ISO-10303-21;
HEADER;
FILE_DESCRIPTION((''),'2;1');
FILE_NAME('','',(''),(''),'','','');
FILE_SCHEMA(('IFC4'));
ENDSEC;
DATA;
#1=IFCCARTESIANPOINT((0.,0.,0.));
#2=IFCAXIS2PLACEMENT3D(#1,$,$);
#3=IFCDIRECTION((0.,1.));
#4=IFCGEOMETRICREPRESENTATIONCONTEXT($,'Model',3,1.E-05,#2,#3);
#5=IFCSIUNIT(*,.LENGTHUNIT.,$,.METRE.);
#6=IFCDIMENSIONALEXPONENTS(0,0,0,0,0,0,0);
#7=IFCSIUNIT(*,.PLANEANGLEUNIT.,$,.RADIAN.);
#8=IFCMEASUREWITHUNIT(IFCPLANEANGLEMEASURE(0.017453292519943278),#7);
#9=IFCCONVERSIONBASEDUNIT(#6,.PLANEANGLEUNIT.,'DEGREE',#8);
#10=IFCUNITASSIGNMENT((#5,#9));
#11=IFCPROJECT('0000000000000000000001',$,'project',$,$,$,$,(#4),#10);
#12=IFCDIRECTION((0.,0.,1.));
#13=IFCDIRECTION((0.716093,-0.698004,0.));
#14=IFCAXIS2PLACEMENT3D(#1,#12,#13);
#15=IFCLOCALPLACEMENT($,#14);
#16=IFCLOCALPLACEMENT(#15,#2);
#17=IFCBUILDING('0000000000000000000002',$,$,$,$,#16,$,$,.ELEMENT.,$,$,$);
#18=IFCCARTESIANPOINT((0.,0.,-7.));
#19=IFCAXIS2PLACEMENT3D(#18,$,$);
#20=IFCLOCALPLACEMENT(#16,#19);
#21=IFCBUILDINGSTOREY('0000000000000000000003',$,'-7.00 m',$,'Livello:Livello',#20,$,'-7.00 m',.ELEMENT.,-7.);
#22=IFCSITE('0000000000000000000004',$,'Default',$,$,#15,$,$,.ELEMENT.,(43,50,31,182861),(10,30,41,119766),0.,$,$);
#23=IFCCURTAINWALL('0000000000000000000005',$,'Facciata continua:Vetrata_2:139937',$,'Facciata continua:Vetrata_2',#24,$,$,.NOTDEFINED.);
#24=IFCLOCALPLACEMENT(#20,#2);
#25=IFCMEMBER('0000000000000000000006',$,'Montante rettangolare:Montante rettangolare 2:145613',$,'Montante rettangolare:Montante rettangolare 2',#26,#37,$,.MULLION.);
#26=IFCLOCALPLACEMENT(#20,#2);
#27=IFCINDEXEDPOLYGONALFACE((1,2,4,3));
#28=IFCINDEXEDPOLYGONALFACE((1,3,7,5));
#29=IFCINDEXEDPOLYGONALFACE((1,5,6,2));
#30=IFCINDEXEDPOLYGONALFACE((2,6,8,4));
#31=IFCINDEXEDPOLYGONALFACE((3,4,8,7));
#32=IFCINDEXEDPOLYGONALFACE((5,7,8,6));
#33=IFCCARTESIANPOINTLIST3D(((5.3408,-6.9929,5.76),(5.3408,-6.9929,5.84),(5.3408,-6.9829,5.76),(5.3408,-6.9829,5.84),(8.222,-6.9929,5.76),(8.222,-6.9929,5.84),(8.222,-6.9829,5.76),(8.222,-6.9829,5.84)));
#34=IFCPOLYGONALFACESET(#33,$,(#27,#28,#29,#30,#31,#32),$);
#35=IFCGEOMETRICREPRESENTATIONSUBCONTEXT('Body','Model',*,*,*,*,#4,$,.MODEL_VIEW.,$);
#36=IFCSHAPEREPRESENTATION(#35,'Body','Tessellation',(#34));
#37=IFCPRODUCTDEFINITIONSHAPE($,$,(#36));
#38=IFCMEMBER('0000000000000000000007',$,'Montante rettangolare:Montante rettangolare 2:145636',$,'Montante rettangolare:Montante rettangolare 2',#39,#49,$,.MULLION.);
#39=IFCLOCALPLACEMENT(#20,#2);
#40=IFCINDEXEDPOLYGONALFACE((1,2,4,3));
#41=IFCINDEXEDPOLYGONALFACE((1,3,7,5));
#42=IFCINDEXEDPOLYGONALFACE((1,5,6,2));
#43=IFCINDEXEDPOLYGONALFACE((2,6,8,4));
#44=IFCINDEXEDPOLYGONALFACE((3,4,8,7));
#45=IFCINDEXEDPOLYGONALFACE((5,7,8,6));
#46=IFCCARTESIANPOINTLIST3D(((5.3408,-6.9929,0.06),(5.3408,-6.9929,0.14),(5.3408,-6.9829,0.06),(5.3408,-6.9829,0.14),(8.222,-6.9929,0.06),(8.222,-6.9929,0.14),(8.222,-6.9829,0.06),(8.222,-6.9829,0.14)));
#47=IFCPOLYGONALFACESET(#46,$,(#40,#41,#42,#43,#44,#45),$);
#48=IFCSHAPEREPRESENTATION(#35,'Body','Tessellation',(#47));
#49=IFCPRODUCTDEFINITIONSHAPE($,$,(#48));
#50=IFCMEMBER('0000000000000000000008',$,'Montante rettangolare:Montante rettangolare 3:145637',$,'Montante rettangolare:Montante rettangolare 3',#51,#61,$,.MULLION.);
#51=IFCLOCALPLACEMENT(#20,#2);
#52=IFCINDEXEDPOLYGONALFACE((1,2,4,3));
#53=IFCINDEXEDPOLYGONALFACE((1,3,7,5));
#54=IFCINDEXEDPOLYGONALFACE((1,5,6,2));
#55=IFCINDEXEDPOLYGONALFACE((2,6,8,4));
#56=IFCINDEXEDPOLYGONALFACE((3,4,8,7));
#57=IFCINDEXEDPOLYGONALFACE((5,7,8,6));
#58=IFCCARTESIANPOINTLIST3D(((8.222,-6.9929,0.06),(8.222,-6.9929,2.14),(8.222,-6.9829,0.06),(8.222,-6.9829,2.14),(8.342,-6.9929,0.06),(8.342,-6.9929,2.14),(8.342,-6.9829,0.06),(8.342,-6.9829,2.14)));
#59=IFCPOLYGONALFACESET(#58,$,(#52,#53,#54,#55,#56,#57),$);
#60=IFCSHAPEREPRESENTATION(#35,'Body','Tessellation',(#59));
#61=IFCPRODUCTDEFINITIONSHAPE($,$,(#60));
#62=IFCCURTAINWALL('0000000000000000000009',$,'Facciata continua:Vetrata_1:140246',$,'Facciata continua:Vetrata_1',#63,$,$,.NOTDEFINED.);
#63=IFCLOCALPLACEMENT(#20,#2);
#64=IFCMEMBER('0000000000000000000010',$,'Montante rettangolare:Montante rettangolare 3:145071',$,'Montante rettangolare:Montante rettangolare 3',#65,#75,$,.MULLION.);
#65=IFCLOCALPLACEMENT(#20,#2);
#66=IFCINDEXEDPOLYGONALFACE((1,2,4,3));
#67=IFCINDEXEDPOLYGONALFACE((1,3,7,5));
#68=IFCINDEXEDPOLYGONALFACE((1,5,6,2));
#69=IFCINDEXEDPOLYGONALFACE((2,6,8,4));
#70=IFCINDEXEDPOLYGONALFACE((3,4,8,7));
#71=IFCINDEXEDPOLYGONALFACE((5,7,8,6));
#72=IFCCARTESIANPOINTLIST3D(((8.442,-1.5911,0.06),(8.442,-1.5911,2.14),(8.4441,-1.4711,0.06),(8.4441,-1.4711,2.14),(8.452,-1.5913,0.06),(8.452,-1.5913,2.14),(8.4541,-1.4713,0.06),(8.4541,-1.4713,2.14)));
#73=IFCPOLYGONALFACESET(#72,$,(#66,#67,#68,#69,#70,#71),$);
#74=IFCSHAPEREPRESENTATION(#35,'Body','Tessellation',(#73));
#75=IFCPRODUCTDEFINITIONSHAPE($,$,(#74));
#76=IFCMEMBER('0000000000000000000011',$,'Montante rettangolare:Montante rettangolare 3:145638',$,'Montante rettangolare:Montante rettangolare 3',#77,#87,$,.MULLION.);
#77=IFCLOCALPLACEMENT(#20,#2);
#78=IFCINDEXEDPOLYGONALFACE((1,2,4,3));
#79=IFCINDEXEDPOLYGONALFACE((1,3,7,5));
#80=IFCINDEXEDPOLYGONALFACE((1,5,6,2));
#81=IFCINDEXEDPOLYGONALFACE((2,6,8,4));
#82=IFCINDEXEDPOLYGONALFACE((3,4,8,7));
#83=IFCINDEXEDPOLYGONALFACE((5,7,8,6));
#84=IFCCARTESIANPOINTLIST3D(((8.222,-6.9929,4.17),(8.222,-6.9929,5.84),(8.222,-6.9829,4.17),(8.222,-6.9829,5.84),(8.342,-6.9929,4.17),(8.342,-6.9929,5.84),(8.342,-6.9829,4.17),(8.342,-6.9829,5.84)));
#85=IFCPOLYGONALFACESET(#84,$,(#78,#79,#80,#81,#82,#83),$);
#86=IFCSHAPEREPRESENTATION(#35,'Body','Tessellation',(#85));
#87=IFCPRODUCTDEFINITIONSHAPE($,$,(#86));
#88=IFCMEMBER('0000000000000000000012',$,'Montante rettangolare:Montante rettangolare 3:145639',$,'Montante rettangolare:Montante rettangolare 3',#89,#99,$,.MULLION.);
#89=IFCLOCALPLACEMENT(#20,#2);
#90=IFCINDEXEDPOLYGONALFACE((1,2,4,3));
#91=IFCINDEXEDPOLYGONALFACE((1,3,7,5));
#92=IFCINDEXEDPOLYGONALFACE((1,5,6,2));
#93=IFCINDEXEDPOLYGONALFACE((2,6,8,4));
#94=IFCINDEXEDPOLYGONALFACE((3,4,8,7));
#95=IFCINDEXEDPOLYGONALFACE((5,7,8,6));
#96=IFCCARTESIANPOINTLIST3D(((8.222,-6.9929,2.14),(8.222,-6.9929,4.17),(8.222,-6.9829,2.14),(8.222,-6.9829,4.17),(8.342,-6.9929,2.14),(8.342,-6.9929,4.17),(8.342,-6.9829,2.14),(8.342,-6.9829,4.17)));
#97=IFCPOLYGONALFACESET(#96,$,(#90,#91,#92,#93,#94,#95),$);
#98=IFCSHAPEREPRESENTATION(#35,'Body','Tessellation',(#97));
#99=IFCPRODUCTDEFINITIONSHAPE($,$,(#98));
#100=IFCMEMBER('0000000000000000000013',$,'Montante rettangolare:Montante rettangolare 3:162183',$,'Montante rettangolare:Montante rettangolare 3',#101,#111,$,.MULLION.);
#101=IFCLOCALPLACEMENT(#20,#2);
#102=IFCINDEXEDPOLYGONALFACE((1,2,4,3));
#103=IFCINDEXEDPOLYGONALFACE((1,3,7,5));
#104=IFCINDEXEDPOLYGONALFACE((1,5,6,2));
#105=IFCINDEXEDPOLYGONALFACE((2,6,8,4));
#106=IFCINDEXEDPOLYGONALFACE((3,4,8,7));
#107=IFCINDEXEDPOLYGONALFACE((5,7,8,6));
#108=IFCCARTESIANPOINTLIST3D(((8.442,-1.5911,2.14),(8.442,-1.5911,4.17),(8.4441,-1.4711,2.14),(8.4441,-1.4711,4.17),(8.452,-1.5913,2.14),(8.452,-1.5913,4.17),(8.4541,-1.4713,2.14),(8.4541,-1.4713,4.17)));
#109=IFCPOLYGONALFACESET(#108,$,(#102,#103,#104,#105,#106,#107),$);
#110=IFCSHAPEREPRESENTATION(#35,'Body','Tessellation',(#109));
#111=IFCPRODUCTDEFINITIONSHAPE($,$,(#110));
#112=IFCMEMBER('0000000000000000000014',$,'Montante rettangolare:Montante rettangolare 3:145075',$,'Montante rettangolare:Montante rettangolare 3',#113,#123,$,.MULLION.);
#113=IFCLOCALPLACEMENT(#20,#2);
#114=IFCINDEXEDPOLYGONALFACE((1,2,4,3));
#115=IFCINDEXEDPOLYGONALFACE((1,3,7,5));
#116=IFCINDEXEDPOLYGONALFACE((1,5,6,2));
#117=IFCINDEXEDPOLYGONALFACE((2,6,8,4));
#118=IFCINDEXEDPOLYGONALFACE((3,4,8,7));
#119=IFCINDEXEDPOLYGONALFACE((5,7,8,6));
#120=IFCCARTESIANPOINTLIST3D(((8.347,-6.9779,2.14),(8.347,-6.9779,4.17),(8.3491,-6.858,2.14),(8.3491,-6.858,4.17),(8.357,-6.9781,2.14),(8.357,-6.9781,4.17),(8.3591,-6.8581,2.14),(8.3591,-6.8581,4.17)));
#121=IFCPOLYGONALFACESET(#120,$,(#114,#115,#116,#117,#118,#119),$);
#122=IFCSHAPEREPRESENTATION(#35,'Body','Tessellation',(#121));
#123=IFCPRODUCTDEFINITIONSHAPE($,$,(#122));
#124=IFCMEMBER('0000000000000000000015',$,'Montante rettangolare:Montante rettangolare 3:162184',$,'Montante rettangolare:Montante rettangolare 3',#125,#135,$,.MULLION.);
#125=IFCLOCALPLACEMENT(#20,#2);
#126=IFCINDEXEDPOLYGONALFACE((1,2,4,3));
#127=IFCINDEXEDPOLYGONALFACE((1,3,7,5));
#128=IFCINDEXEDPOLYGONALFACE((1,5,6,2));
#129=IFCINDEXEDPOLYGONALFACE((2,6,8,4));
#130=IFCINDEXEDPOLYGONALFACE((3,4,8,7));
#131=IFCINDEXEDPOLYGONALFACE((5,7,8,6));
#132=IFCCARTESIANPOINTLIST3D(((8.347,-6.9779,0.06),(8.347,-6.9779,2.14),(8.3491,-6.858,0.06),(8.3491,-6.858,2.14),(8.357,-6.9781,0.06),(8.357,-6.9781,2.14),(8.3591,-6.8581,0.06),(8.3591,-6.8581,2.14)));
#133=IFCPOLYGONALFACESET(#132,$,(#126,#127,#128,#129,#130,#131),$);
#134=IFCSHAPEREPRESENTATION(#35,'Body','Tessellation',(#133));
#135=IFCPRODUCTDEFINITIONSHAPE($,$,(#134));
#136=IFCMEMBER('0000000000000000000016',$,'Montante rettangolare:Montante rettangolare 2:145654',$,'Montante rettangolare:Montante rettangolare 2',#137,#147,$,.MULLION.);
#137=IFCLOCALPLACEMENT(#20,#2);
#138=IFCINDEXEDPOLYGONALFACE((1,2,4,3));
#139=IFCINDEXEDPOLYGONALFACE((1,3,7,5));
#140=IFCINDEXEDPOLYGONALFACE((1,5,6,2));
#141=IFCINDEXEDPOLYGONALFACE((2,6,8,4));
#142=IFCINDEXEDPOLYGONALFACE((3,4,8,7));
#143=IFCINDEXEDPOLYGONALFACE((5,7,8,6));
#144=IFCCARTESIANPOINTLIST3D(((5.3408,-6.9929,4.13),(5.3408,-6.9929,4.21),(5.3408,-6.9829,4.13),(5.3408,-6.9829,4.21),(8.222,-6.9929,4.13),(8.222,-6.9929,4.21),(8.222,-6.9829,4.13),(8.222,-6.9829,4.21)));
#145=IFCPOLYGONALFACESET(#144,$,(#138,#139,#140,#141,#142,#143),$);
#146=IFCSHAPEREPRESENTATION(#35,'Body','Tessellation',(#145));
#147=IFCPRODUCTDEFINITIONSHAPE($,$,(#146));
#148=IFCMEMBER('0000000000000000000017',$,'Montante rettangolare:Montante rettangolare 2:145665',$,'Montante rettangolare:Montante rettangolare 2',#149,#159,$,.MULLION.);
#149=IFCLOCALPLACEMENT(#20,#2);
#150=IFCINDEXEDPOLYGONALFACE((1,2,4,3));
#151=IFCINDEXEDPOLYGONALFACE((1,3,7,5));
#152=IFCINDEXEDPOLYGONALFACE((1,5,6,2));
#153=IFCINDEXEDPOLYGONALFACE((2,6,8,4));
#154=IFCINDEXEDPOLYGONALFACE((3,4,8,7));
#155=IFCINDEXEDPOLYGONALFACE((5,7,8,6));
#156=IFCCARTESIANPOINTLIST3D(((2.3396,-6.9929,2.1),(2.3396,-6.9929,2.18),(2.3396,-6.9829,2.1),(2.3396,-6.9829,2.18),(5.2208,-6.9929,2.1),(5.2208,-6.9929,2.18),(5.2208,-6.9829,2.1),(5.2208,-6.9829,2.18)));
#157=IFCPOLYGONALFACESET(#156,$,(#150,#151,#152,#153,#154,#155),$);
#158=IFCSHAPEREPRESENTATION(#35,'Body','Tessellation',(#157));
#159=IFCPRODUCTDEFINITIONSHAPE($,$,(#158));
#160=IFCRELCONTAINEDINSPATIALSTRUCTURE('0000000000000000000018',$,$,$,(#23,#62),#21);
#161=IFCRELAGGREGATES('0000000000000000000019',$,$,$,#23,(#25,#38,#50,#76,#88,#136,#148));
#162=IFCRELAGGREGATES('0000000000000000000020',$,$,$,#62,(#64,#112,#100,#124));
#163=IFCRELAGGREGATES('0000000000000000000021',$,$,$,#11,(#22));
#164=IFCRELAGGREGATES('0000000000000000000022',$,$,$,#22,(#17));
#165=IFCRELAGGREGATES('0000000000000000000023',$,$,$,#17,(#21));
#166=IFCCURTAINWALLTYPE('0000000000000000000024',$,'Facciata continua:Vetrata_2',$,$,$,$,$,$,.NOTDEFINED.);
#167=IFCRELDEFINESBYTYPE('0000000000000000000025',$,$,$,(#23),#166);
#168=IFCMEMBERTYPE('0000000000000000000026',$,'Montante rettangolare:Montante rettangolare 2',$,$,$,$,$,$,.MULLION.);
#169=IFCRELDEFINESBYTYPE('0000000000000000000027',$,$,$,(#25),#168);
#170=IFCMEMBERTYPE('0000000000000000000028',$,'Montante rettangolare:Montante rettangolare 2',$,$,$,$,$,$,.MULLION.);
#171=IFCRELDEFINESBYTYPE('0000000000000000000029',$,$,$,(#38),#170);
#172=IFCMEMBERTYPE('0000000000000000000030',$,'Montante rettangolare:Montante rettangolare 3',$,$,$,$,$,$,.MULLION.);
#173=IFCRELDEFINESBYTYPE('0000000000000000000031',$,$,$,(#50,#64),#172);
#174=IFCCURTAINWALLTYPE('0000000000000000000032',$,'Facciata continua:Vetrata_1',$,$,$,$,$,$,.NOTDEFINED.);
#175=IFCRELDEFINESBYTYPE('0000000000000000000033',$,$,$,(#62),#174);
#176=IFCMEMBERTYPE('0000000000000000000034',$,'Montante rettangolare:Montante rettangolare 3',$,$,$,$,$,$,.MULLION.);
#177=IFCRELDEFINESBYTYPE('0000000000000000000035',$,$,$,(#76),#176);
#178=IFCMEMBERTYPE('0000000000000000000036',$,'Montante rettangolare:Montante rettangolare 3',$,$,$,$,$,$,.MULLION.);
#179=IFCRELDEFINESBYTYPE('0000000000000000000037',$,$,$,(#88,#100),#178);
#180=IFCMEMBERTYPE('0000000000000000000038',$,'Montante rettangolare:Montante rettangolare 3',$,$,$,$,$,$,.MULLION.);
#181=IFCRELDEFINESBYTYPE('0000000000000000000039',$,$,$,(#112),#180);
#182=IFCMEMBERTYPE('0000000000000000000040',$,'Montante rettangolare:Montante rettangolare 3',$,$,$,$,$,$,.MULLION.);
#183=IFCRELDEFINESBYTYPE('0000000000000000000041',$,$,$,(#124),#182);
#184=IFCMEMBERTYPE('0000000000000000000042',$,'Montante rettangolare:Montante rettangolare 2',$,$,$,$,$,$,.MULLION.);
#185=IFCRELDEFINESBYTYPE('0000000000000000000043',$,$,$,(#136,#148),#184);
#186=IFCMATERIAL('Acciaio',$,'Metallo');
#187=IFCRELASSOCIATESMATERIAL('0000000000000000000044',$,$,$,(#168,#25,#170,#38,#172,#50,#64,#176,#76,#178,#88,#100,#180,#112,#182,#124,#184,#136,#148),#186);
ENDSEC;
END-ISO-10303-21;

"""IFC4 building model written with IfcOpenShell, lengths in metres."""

from ifc_helpers import new_model, entity, si_unit, converted_unit, direction, frame, origin, place, context, subcontext, project, spatial, indexed_curve, outline, extrude, source, transform, mapped, material, type_object, type_shapes, element, aggregate, save


model = new_model("IFC4")

# Units and contexts
model_context = context("Model", 3, precision=1e-05, world=origin(), true_north=direction((0.0, 1.0)))
body_context = subcontext(model_context, "Body", "Model", "MODEL_VIEW")
ifc_project = project(units=[si_unit("LENGTHUNIT", "METRE"), converted_unit("PLANEANGLEUNIT", "DEGREE", entity("IfcPlaneAngleMeasure", 0.017453292519943278), si_unit("PLANEANGLEUNIT", "RADIAN"), dimensions=[0, 0, 0, 0, 0, 0, 0])], contexts=[model_context])

# Site, building, storey
site_placement = place(None, frame((0.0, 0.0, 0.0), z_axis=(0.0, 0.0, 1.0), x_axis=(0.716093, -0.698004, 0.0)))
site = spatial("IfcSite", under=ifc_project, at=site_placement, Name="Default", CompositionType="ELEMENT", RefLatitude=(43, 50, 31, 182861), RefLongitude=(10, 30, 41, 119766), RefElevation=0.0)
building_placement = place(site_placement, origin())
building = spatial("IfcBuilding", under=site, at=building_placement, CompositionType="ELEMENT")
storey_placement = place(building_placement, frame((0.0, 0.0, -7.0)))
storey = spatial("IfcBuildingStorey", under=building, at=storey_placement, Name="-7.00 m", ObjectType="Livello:Livello", LongName="-7.00 m", CompositionType="ELEMENT", Elevation=-7.0)

# Curtain wall, members
curtain_wall_type_1 = type_object("IfcCurtainWallType", Name="Facciata continua:Vetrata_2", PredefinedType="NOTDEFINED")
curtain_wall_1_placement = place(storey_placement, frame((0.0, 0.0, 7.0)))
curtain_wall_1 = element("IfcCurtainWall", 1, at=curtain_wall_1_placement, inside=storey, type_object=curtain_wall_type_1, Name="Facciata continua:Vetrata_2:139937", ObjectType="Facciata continua:Vetrata_2", PredefinedType="NOTDEFINED")
ifc_material_1 = material(Name="Acciaio", Category="Metallo")
member_type_1 = type_object("IfcMemberType", Name="Montante rettangolare:Montante rettangolare 2", PredefinedType="MULLION", material=ifc_material_1)
shared_shape_1 = source(origin(), body_context, "Body", "SweptSolid", [
    extrude(outline(indexed_curve([(-0.04, -0.005), (0.04, -0.005), (0.04, 0.005), (-0.04, 0.005), (-0.04, -0.005)], self_intersect=False)), frame((-0.04, 0.01, -2.8812), z_axis=(0.0, 0.0, 1.0), x_axis=(-1.0, 0.0, 0.0)), (0.0, 0.0, 1.0), 2.8812),
])
type_shapes(member_type_1, [shared_shape_1])
member_1_placement = place(curtain_wall_1_placement, frame((8.222, -6.9779, -1.16), z_axis=(1.0, 0.0, 0.0), x_axis=(0.0, 0.0, 1.0)))
member_1 = element("IfcMember", 2, at=member_1_placement, type_object=member_type_1, material=ifc_material_1, Name="Montante rettangolare:Montante rettangolare 2:145613", ObjectType="Montante rettangolare:Montante rettangolare 2", PredefinedType="MULLION", context=body_context, shape_type="MappedRepresentation", body=[
    mapped(shared_shape_1, transform((0.0, 0.0, 0.0), scale=1.0)),
])
member_type_2 = type_object("IfcMemberType", Name="Montante rettangolare:Montante rettangolare 2", PredefinedType="MULLION", material=ifc_material_1)
shared_shape_2 = source(origin(), body_context, "Body", "SweptSolid", [
    extrude(outline(indexed_curve([(-0.04, -0.005), (0.04, -0.005), (0.04, 0.005), (-0.04, 0.005), (-0.04, -0.005)], self_intersect=False)), frame((-0.04, 0.01, -2.8812), z_axis=(0.0, 0.0, 1.0), x_axis=(-1.0, 0.0, 0.0)), (0.0, 0.0, 1.0), 2.8812),
])
type_shapes(member_type_2, [shared_shape_2])
member_2_placement = place(curtain_wall_1_placement, frame((5.3408, -6.9779, -6.94), z_axis=(-1.0, 0.0, 0.0), x_axis=(0.0, 0.0, -1.0)))
member_2 = element("IfcMember", 3, at=member_2_placement, type_object=member_type_2, material=ifc_material_1, Name="Montante rettangolare:Montante rettangolare 2:145636", ObjectType="Montante rettangolare:Montante rettangolare 2", PredefinedType="MULLION", context=body_context, shape_type="MappedRepresentation", body=[
    mapped(shared_shape_2, transform((0.0, 0.0, 0.0), scale=1.0)),
])
member_type_3 = type_object("IfcMemberType", Name="Montante rettangolare:Montante rettangolare 3", PredefinedType="MULLION", material=ifc_material_1)
shared_shape_3 = source(origin(), body_context, "Body", "SweptSolid", [
    extrude(outline(indexed_curve([(-0.06, -0.005), (0.06, -0.005), (0.06, 0.005), (-0.06, 0.005), (-0.06, -0.005)], self_intersect=False)), frame((-0.06, 0.01, -2.08), z_axis=(0.0, 0.0, 1.0), x_axis=(-1.0, 0.0, 0.0)), (0.0, 0.0, 1.0), 2.08),
])
type_shapes(member_type_3, [shared_shape_3])
member_3_placement = place(curtain_wall_1_placement, frame((8.342, -6.9779, -6.94), z_axis=(0.0, 0.0, -1.0), x_axis=(1.0, 0.0, 0.0)))
member_3 = element("IfcMember", 4, at=member_3_placement, type_object=member_type_3, material=ifc_material_1, Name="Montante rettangolare:Montante rettangolare 3:145637", ObjectType="Montante rettangolare:Montante rettangolare 3", PredefinedType="MULLION", context=body_context, shape_type="MappedRepresentation", body=[
    mapped(shared_shape_3, transform((0.0, 0.0, 0.0), scale=1.0)),
])

# Curtain wall, member
curtain_wall_type_2 = type_object("IfcCurtainWallType", Name="Facciata continua:Vetrata_1", PredefinedType="NOTDEFINED")
curtain_wall_2_placement = place(storey_placement, frame((0.0, 0.0, 7.0)))
curtain_wall_2 = element("IfcCurtainWall", 5, at=curtain_wall_2_placement, inside=storey, type_object=curtain_wall_type_2, Name="Facciata continua:Vetrata_1:140246", ObjectType="Facciata continua:Vetrata_1", PredefinedType="NOTDEFINED")
member_4_placement = place(curtain_wall_2_placement, frame((8.4391, -1.471, -6.94), z_axis=(0.0, 0.0, -1.0), x_axis=(0.017636, 0.999844, 0.0)))
member_4 = element("IfcMember", 6, at=member_4_placement, type_object=member_type_3, material=ifc_material_1, Name="Montante rettangolare:Montante rettangolare 3:145071", ObjectType="Montante rettangolare:Montante rettangolare 3", PredefinedType="MULLION", context=body_context, shape_type="MappedRepresentation", body=[
    mapped(shared_shape_3, transform((0.0, 0.0, 0.0), scale=1.0)),
])

# Members
member_type_4 = type_object("IfcMemberType", Name="Montante rettangolare:Montante rettangolare 3", PredefinedType="MULLION", material=ifc_material_1)
shared_shape_4 = source(origin(), body_context, "Body", "SweptSolid", [
    extrude(outline(indexed_curve([(-0.06, -0.005), (0.06, -0.005), (0.06, 0.005), (-0.06, 0.005), (-0.06, -0.005)], self_intersect=False)), frame((-0.06, 0.01, -1.67), z_axis=(0.0, 0.0, 1.0), x_axis=(-1.0, 0.0, 0.0)), (0.0, 0.0, 1.0), 1.67),
])
type_shapes(member_type_4, [shared_shape_4])
member_5_placement = place(curtain_wall_1_placement, frame((8.342, -6.9779, -2.83), z_axis=(0.0, 0.0, -1.0), x_axis=(1.0, 0.0, 0.0)))
member_5 = element("IfcMember", 7, at=member_5_placement, type_object=member_type_4, material=ifc_material_1, Name="Montante rettangolare:Montante rettangolare 3:145638", ObjectType="Montante rettangolare:Montante rettangolare 3", PredefinedType="MULLION", context=body_context, shape_type="MappedRepresentation", body=[
    mapped(shared_shape_4, transform((0.0, 0.0, 0.0), scale=1.0)),
])
member_type_5 = type_object("IfcMemberType", Name="Montante rettangolare:Montante rettangolare 3", PredefinedType="MULLION", material=ifc_material_1)
shared_shape_5 = source(origin(), body_context, "Body", "SweptSolid", [
    extrude(outline(indexed_curve([(-0.06, -0.005), (0.06, -0.005), (0.06, 0.005), (-0.06, 0.005), (-0.06, -0.005)], self_intersect=False)), frame((-0.06, 0.01, -2.03), z_axis=(0.0, 0.0, 1.0), x_axis=(-1.0, 0.0, 0.0)), (0.0, 0.0, 1.0), 2.03),
])
type_shapes(member_type_5, [shared_shape_5])
member_6_placement = place(curtain_wall_1_placement, frame((8.342, -6.9779, -4.86), z_axis=(0.0, 0.0, -1.0), x_axis=(1.0, 0.0, 0.0)))
member_6 = element("IfcMember", 8, at=member_6_placement, type_object=member_type_5, material=ifc_material_1, Name="Montante rettangolare:Montante rettangolare 3:145639", ObjectType="Montante rettangolare:Montante rettangolare 3", PredefinedType="MULLION", context=body_context, shape_type="MappedRepresentation", body=[
    mapped(shared_shape_5, transform((0.0, 0.0, 0.0), scale=1.0)),
])
member_7_placement = place(curtain_wall_2_placement, frame((8.4391, -1.471, -4.86), z_axis=(0.0, 0.0, -1.0), x_axis=(0.017636, 0.999844, 0.0)))
member_7 = element("IfcMember", 9, at=member_7_placement, type_object=member_type_5, material=ifc_material_1, Name="Montante rettangolare:Montante rettangolare 3:162183", ObjectType="Montante rettangolare:Montante rettangolare 3", PredefinedType="MULLION", context=body_context, shape_type="MappedRepresentation", body=[
    mapped(shared_shape_5, transform((0.0, 0.0, 0.0), scale=1.0)),
])
member_type_6 = type_object("IfcMemberType", Name="Montante rettangolare:Montante rettangolare 3", PredefinedType="MULLION", material=ifc_material_1)
shared_shape_6 = source(origin(), body_context, "Body", "SweptSolid", [
    extrude(outline(indexed_curve([(-0.06, -0.005), (0.06, -0.005), (0.06, 0.005), (-0.06, 0.005), (-0.06, -0.005)], self_intersect=False)), frame((-0.06, 0.01, -2.03), z_axis=(0.0, 0.0, 1.0), x_axis=(-1.0, 0.0, 0.0)), (0.0, 0.0, 1.0), 2.03),
])
type_shapes(member_type_6, [shared_shape_6])
member_8_placement = place(curtain_wall_2_placement, frame((8.342, -6.9779, -2.83), z_axis=(0.0, 0.0, 1.0), x_axis=(-0.017636, -0.999844, 0.0)))
member_8 = element("IfcMember", 10, at=member_8_placement, type_object=member_type_6, material=ifc_material_1, Name="Montante rettangolare:Montante rettangolare 3:145075", ObjectType="Montante rettangolare:Montante rettangolare 3", PredefinedType="MULLION", context=body_context, shape_type="MappedRepresentation", body=[
    mapped(shared_shape_6, transform((0.0, 0.0, 0.0), scale=1.0)),
])
member_type_7 = type_object("IfcMemberType", Name="Montante rettangolare:Montante rettangolare 3", PredefinedType="MULLION", material=ifc_material_1)
shared_shape_7 = source(origin(), body_context, "Body", "SweptSolid", [
    extrude(outline(indexed_curve([(-0.06, -0.005), (0.06, -0.005), (0.06, 0.005), (-0.06, 0.005), (-0.06, -0.005)], self_intersect=False)), frame((-0.06, 0.01, -2.08), z_axis=(0.0, 0.0, 1.0), x_axis=(-1.0, 0.0, 0.0)), (0.0, 0.0, 1.0), 2.08),
])
type_shapes(member_type_7, [shared_shape_7])
member_9_placement = place(curtain_wall_2_placement, frame((8.342, -6.9779, -4.86), z_axis=(0.0, 0.0, 1.0), x_axis=(-0.017636, -0.999844, 0.0)))
member_9 = element("IfcMember", 11, at=member_9_placement, type_object=member_type_7, material=ifc_material_1, Name="Montante rettangolare:Montante rettangolare 3:162184", ObjectType="Montante rettangolare:Montante rettangolare 3", PredefinedType="MULLION", context=body_context, shape_type="MappedRepresentation", body=[
    mapped(shared_shape_7, transform((0.0, 0.0, 0.0), scale=1.0)),
])
member_type_8 = type_object("IfcMemberType", Name="Montante rettangolare:Montante rettangolare 2", PredefinedType="MULLION", material=ifc_material_1)
shared_shape_8 = source(origin(), body_context, "Body", "SweptSolid", [
    extrude(outline(indexed_curve([(-0.04, -0.005), (0.04, -0.005), (0.04, 0.005), (-0.04, 0.005), (-0.04, -0.005)], self_intersect=False)), frame((0.0, 0.01, -2.8812), z_axis=(0.0, 0.0, 1.0), x_axis=(-1.0, 0.0, 0.0)), (0.0, 0.0, 1.0), 2.8812),
])
type_shapes(member_type_8, [shared_shape_8])
member_10_placement = place(curtain_wall_1_placement, frame((8.222, -6.9779, -2.83), z_axis=(1.0, 0.0, 0.0), x_axis=(0.0, 0.0, 1.0)))
member_10 = element("IfcMember", 12, at=member_10_placement, type_object=member_type_8, material=ifc_material_1, Name="Montante rettangolare:Montante rettangolare 2:145654", ObjectType="Montante rettangolare:Montante rettangolare 2", PredefinedType="MULLION", context=body_context, shape_type="MappedRepresentation", body=[
    mapped(shared_shape_8, transform((0.0, 0.0, 0.0), scale=1.0)),
])
member_11_placement = place(curtain_wall_1_placement, frame((5.2208, -6.9779, -4.86), z_axis=(1.0, 0.0, 0.0), x_axis=(0.0, 0.0, 1.0)))
member_11 = element("IfcMember", 13, at=member_11_placement, type_object=member_type_8, material=ifc_material_1, Name="Montante rettangolare:Montante rettangolare 2:145665", ObjectType="Montante rettangolare:Montante rettangolare 2", PredefinedType="MULLION", context=body_context, shape_type="MappedRepresentation", body=[
    mapped(shared_shape_8, transform((0.0, 0.0, 0.0), scale=1.0)),
])
aggregate(curtain_wall_1, [member_1, member_2, member_3, member_5, member_6, member_10, member_11])

aggregate(curtain_wall_2, [member_4, member_8, member_7, member_9])

save(model, "model.ifc")
